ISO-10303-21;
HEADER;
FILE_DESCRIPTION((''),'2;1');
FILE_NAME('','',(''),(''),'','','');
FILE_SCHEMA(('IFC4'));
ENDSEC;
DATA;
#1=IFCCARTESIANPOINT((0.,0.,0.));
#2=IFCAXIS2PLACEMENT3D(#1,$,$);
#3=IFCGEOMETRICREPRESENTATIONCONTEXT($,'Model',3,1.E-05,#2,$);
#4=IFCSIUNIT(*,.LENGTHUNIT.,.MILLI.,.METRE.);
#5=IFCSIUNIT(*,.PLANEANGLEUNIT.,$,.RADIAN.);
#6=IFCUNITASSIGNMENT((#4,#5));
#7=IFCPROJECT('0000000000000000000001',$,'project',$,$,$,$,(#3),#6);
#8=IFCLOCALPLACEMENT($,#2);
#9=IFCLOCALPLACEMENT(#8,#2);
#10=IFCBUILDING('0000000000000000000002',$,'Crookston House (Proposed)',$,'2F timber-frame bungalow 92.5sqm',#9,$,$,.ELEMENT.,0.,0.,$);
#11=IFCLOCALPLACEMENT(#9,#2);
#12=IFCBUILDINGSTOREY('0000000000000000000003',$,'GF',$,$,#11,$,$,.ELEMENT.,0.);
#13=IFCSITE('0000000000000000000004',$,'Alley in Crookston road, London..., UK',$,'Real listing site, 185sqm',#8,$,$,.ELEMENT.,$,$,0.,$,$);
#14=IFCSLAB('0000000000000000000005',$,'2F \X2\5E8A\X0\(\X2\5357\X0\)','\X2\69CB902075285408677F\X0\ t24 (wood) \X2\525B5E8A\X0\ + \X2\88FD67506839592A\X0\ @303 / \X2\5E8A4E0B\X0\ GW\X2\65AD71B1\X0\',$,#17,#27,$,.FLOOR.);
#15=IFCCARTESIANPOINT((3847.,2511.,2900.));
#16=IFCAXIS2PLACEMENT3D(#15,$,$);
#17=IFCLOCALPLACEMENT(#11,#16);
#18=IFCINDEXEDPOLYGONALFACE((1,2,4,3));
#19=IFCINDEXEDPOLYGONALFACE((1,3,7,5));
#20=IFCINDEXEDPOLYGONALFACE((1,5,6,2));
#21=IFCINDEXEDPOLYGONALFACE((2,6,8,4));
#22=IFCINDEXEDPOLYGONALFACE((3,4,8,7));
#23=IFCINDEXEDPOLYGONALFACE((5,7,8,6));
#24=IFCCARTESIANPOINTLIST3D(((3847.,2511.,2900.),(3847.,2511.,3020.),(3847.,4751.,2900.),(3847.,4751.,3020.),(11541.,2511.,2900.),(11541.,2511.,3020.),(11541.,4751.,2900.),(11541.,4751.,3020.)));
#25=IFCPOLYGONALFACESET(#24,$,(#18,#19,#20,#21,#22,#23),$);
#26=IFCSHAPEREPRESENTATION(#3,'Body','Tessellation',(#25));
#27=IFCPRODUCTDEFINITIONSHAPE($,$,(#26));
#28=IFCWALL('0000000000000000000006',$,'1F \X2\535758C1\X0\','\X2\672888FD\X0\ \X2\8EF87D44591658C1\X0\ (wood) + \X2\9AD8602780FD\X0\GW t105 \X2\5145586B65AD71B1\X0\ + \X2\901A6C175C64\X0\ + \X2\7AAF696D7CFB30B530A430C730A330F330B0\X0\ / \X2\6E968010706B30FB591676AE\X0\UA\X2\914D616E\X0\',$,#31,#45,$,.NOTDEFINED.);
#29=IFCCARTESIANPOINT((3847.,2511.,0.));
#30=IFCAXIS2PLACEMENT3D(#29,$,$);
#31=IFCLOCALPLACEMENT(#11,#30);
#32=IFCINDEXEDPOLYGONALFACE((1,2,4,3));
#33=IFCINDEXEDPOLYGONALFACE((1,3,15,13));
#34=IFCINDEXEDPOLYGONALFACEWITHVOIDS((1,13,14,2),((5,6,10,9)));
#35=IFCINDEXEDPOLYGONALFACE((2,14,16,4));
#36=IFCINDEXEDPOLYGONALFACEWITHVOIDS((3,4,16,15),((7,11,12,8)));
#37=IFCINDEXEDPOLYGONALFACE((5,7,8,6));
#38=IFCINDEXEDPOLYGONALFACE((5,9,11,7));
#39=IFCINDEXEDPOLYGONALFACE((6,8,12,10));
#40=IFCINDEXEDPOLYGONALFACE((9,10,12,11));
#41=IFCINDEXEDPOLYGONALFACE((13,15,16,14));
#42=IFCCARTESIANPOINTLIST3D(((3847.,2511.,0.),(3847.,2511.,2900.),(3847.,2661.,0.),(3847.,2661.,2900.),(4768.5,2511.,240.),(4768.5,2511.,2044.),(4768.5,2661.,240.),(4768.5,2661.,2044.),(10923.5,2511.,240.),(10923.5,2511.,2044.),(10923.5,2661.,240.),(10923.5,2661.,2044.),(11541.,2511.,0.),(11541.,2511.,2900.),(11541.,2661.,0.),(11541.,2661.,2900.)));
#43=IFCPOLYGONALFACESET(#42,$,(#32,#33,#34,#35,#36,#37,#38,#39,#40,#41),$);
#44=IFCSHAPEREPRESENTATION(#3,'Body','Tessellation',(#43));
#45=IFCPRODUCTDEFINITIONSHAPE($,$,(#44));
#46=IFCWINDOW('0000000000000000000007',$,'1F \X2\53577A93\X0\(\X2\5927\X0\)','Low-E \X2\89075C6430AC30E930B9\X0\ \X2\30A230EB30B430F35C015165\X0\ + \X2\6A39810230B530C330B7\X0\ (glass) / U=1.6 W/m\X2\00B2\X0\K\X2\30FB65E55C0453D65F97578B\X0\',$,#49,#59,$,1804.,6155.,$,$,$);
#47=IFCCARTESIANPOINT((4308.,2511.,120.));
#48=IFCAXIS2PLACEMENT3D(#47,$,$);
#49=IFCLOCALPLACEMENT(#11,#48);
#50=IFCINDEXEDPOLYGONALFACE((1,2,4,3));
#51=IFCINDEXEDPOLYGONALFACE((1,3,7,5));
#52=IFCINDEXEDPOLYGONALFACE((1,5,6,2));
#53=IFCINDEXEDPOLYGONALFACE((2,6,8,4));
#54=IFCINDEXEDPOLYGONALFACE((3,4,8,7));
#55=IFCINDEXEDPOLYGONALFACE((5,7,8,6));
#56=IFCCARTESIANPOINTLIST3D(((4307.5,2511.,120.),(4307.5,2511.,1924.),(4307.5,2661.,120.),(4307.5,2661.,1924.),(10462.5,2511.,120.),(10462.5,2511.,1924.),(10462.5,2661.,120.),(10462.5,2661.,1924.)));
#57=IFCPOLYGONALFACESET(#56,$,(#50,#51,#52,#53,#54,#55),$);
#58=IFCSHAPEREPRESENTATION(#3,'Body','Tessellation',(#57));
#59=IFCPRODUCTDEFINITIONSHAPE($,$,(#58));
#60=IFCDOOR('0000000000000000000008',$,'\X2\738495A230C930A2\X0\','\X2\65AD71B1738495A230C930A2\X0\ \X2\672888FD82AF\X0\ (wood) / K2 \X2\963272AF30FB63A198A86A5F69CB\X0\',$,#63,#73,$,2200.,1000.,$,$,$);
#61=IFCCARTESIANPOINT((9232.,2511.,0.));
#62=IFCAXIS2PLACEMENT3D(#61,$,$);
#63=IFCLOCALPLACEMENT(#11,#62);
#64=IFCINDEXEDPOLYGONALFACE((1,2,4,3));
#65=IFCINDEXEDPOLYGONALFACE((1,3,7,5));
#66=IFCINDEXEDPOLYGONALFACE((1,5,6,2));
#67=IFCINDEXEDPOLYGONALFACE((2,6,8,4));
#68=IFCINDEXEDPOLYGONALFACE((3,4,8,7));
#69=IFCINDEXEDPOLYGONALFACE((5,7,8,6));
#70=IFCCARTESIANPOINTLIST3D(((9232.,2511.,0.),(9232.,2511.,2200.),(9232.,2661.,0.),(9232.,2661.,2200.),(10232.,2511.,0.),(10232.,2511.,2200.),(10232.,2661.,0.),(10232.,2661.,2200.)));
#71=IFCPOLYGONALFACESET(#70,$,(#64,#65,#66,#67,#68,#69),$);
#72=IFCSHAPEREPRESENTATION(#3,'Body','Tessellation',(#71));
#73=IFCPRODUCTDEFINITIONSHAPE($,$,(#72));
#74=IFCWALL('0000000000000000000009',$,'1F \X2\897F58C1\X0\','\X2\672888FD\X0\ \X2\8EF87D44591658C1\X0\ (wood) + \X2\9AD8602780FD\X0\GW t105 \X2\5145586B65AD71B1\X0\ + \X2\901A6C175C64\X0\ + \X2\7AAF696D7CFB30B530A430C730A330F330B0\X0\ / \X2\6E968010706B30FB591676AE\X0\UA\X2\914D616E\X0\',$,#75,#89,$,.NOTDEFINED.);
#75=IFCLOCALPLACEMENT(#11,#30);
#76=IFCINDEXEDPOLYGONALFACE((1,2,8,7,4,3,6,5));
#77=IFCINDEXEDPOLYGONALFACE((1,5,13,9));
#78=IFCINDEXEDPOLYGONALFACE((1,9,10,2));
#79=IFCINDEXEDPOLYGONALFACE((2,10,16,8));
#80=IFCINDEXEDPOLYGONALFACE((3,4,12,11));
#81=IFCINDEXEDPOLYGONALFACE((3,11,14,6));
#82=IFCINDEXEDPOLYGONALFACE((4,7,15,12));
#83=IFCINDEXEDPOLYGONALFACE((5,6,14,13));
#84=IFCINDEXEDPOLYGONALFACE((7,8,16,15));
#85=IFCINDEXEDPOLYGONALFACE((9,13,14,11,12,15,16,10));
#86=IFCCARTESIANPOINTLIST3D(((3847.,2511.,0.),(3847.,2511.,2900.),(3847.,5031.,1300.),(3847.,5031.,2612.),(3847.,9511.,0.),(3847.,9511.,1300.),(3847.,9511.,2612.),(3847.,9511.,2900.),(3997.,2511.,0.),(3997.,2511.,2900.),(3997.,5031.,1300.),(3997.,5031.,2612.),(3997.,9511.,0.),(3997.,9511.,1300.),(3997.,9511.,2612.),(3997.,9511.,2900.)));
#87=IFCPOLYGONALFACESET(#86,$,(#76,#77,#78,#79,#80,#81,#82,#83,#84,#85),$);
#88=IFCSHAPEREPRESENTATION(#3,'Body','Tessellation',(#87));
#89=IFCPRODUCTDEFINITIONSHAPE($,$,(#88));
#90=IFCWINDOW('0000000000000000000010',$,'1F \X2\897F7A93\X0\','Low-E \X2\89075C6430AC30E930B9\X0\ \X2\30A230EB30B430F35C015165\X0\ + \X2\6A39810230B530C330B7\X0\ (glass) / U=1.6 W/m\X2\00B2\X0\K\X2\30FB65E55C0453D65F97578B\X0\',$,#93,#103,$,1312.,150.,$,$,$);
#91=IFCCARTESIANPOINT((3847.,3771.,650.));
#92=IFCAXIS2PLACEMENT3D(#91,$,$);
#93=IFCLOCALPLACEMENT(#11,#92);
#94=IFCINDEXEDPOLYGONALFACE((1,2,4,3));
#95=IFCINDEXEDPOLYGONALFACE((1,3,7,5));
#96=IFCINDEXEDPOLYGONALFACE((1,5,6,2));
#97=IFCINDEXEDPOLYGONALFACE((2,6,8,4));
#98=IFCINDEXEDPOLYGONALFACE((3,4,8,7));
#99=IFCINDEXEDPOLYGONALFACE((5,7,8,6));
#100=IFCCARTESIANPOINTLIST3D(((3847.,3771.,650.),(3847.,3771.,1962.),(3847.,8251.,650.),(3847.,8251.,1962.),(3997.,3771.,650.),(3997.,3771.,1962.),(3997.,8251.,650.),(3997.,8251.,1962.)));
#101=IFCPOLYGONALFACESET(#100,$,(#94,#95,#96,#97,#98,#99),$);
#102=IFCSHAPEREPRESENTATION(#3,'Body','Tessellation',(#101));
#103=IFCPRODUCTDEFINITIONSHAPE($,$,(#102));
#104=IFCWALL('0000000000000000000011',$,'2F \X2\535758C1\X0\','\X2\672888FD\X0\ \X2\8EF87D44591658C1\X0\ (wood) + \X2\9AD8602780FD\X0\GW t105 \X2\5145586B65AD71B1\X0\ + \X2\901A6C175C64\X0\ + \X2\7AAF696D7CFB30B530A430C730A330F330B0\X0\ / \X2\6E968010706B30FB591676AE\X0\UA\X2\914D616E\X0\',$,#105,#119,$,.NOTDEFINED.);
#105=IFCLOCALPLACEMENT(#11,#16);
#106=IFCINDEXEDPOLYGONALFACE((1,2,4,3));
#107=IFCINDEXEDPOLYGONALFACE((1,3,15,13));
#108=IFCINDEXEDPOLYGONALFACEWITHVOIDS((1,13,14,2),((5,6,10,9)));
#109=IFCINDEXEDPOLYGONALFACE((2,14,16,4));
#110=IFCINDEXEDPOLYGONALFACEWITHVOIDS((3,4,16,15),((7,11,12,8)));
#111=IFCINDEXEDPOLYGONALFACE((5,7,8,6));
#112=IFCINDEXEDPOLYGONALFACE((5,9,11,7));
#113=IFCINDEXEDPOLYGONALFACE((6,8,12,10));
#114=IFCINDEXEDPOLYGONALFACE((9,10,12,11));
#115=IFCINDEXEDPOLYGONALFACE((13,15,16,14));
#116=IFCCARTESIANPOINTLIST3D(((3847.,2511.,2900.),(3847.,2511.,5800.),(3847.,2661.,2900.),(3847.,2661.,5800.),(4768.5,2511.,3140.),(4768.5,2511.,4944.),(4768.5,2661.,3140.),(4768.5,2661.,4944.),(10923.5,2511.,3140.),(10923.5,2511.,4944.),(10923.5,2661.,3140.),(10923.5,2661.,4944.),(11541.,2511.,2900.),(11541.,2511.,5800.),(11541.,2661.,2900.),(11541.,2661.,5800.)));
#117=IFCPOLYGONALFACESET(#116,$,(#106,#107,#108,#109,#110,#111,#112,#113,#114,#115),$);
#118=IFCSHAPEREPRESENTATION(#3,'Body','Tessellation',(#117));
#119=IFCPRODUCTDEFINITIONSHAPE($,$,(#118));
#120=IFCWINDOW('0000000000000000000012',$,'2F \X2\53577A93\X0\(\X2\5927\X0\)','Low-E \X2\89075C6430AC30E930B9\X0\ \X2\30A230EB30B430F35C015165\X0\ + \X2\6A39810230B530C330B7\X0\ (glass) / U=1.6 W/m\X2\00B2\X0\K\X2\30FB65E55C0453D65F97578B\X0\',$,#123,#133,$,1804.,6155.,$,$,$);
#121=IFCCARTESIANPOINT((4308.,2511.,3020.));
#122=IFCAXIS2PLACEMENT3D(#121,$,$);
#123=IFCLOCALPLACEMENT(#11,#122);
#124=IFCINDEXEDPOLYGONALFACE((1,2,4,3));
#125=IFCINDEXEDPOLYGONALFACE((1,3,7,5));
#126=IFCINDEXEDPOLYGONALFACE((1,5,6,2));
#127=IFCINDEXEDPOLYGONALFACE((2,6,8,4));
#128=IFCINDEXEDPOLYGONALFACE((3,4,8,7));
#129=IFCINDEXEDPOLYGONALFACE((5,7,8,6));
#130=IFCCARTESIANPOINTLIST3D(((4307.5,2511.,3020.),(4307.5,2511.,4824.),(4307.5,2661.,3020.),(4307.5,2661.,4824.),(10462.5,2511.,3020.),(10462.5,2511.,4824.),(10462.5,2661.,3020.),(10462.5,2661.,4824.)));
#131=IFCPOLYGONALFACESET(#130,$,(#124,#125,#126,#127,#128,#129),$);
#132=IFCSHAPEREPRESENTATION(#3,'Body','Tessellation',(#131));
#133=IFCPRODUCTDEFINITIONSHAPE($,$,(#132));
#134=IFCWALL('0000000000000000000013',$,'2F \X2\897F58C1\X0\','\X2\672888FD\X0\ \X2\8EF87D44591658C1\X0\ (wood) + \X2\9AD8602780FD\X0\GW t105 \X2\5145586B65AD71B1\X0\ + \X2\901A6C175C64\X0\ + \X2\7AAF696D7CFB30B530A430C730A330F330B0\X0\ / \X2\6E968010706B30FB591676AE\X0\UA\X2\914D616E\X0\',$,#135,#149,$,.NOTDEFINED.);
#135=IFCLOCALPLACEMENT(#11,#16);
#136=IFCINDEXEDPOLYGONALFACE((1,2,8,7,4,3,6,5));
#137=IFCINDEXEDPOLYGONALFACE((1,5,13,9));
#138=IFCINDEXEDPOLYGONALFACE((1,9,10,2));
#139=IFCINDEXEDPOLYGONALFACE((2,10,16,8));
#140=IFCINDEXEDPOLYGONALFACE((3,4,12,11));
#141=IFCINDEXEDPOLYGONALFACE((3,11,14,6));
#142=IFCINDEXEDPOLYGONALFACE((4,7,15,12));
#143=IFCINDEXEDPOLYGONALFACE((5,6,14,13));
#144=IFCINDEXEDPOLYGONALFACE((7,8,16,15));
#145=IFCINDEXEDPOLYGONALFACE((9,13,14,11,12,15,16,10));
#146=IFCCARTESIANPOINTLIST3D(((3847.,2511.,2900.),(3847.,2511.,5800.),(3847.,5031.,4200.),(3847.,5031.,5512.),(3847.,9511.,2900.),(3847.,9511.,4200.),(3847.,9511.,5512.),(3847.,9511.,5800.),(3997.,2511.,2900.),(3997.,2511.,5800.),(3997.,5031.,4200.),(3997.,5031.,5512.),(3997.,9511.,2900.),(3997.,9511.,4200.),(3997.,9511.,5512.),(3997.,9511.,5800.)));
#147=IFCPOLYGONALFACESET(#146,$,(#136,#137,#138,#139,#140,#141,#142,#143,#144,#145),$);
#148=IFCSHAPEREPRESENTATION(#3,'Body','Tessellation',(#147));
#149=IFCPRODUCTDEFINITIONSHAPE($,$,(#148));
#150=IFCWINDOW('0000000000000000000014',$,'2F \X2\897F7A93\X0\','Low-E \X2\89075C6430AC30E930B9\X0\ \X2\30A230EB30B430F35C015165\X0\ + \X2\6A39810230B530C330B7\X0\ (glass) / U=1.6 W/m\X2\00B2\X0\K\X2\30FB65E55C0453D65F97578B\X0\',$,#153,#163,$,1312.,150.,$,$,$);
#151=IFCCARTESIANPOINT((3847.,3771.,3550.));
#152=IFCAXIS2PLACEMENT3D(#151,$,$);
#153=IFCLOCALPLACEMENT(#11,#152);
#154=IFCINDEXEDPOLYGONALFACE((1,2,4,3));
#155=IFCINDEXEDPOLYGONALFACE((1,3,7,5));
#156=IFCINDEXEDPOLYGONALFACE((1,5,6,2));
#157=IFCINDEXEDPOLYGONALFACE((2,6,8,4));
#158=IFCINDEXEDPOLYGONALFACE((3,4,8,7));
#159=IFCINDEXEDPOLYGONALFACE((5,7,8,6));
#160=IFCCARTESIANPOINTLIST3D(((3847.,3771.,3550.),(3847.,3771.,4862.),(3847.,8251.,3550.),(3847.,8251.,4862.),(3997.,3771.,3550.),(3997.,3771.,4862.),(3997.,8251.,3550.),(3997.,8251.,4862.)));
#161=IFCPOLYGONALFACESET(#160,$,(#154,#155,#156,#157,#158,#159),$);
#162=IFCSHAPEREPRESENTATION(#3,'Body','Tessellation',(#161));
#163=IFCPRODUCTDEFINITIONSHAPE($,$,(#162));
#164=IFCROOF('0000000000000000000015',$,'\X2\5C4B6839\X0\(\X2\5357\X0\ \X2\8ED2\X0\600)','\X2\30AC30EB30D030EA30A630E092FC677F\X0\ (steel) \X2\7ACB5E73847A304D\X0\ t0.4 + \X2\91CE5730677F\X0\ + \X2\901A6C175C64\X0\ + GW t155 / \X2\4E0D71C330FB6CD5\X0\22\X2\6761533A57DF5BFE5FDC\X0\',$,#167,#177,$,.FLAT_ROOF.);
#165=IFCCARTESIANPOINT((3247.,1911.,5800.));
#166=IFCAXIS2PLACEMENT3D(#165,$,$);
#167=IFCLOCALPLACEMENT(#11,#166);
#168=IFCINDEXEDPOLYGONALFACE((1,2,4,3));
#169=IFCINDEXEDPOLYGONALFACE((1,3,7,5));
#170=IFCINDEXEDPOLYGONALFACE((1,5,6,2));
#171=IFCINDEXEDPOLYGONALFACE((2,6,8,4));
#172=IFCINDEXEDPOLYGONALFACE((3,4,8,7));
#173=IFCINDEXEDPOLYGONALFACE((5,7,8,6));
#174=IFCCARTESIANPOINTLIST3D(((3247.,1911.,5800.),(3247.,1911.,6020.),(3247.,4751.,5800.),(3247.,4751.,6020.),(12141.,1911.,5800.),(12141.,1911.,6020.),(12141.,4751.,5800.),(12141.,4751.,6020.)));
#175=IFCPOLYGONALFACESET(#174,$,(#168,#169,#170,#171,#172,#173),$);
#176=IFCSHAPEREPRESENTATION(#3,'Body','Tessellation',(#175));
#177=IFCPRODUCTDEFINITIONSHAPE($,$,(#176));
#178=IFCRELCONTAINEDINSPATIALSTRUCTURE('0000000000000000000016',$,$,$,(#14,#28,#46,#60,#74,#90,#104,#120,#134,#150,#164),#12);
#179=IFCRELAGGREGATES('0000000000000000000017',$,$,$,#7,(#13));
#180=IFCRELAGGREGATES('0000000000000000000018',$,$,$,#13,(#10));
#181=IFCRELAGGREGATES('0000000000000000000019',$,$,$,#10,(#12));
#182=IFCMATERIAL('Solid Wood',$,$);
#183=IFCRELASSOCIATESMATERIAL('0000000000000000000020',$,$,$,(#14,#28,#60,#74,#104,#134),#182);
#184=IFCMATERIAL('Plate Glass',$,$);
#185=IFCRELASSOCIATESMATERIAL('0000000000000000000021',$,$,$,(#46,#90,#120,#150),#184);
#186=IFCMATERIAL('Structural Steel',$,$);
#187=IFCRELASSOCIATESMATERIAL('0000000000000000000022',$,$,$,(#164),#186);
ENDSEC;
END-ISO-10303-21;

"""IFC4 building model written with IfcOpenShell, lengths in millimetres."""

from ifc_helpers import new_model, si_unit, frame, frame_2d, origin, place, context, project, spatial, rectangle, extrude, material, element, fill, save


model = new_model("IFC4")

# Units and contexts
model_context = context("Model", 3, precision=1e-05, world=origin())
ifc_project = project(units=[si_unit("LENGTHUNIT", "METRE", prefix="MILLI"), si_unit("PLANEANGLEUNIT", "RADIAN")], contexts=[model_context])

# Site, building, storey
site_placement = place(None, origin())
site = spatial("IfcSite", under=ifc_project, at=site_placement, Name="Alley in Crookston road, London..., UK", ObjectType="Real listing site, 185sqm", CompositionType="ELEMENT", RefElevation=0.0)
building_placement = place(site_placement, origin())
building = spatial("IfcBuilding", under=site, at=building_placement, Name="Crookston House (Proposed)", ObjectType="2F timber-frame bungalow 92.5sqm", CompositionType="ELEMENT", ElevationOfRefHeight=0.0, ElevationOfTerrain=0.0)
storey_placement = place(building_placement, origin())
storey = spatial("IfcBuildingStorey", under=building, at=storey_placement, Name="GF", CompositionType="ELEMENT", Elevation=0.0)

# Slab
ifc_material_1 = material(Name="Solid Wood")
slab_1_placement = place(storey_placement, frame((3847.0, 2511.0, 2900.0)))
element("IfcSlab", 1, at=slab_1_placement, inside=storey, material=ifc_material_1, Name="2F 床(南)", Description="構造用合板 t24 (wood) 剛床 + 製材根太 @303 / 床下 GW断熱", PredefinedType="FLOOR", context=model_context, shape_type="SweptSolid", body=[
    extrude(rectangle(XDim=7694.0, YDim=2240.0, at=frame_2d((3847.0, 1120.0))), frame((3847.0, 2511.0, 2900.0)), (0.0, 0.0, 1.0), 120.0),
])

# Wall, openings, window, door
wall_1_placement = place(storey_placement, frame((3847.0, 2511.0, 0.0)))
wall_1 = element("IfcWall", 2, at=wall_1_placement, inside=storey, material=ifc_material_1, Name="1F 南壁", Description="木製 軸組外壁 (wood) + 高性能GW t105 充填断熱 + 通気層 + 窯業系サイディング / 準耐火・外皮UA配慮", PredefinedType="NOTDEFINED", context=model_context, shape_type="SweptSolid", body=[
    extrude(rectangle(XDim=7694.0, YDim=150.0, at=frame_2d((3847.0, 75.0))), frame((3847.0, 2511.0, 0.0)), (0.0, 0.0, 1.0), 2900.0),
])
opening_1_placement = place(storey_placement, frame((4308.0, 2511.0, 120.0)))
opening_1 = element("IfcOpeningElement", 3, at=opening_1_placement, cuts=wall_1, PredefinedType="NOTDEFINED", context=model_context, shape_type="SweptSolid", body=[
    extrude(rectangle(XDim=6155.0, YDim=150.0, at=frame_2d((3077.0, 75.0))), frame((4308.0, 2511.0, 120.0)), (0.0, 0.0, 1.0), 1804.0),
])
opening_2_placement = place(storey_placement, frame((9232.0, 2511.0, 0.0)))
opening_2 = element("IfcOpeningElement", 4, at=opening_2_placement, cuts=wall_1, PredefinedType="NOTDEFINED", context=model_context, shape_type="SweptSolid", body=[
    extrude(rectangle(XDim=1000.0, YDim=150.0, at=frame_2d((500.0, 75.0))), frame((9232.0, 2511.0, 0.0)), (0.0, 0.0, 1.0), 2200.0),
])
ifc_material_2 = material(Name="Plate Glass")
window_1_placement = place(storey_placement, frame((4308.0, 2511.0, 120.0)))
window_1 = element("IfcWindow", 5, at=window_1_placement, inside=storey, material=ifc_material_2, Name="1F 南窓(大)", Description="Low-E 複層ガラス アルゴン封入 + 樹脂サッシ (glass) / U=1.6 W/m²K・日射取得型", OverallHeight=1804.0, OverallWidth=6155.0, context=model_context, shape_type="SweptSolid", body=[
    extrude(rectangle(XDim=6155.0, YDim=150.0, at=frame_2d((3077.0, 75.0))), frame((4308.0, 2511.0, 120.0)), (0.0, 0.0, 1.0), 1804.0),
])
fill(opening_1, window_1)
door_placement = place(storey_placement, frame((9232.0, 2511.0, 0.0)))
door = element("IfcDoor", 6, at=door_placement, inside=storey, material=ifc_material_1, Name="玄関ドア", Description="断熱玄関ドア 木製芯 (wood) / K2 防犯・採風機構", OverallHeight=2200.0, OverallWidth=1000.0, context=model_context, shape_type="SweptSolid", body=[
    extrude(rectangle(XDim=1000.0, YDim=150.0, at=frame_2d((500.0, 75.0))), frame((9232.0, 2511.0, 0.0)), (0.0, 0.0, 1.0), 2200.0),
])
fill(opening_2, door)

# Walls, openings, windows
wall_2_placement = place(storey_placement, frame((3847.0, 2511.0, 0.0)))
wall_2 = element("IfcWall", 7, at=wall_2_placement, inside=storey, material=ifc_material_1, Name="1F 西壁", Description="木製 軸組外壁 (wood) + 高性能GW t105 充填断熱 + 通気層 + 窯業系サイディング / 準耐火・外皮UA配慮", PredefinedType="NOTDEFINED", context=model_context, shape_type="SweptSolid", body=[
    extrude(rectangle(XDim=150.0, YDim=7000.0, at=frame_2d((75.0, 3500.0))), frame((3847.0, 2511.0, 0.0)), (0.0, 0.0, 1.0), 2900.0),
])
opening_3_placement = place(storey_placement, frame((3847.0, 3771.0, 650.0)))
opening_3 = element("IfcOpeningElement", 8, at=opening_3_placement, cuts=wall_2, PredefinedType="NOTDEFINED", context=model_context, shape_type="SweptSolid", body=[
    extrude(rectangle(XDim=150.0, YDim=4480.0, at=frame_2d((75.0, 2240.0))), frame((3847.0, 3771.0, 650.0)), (0.0, 0.0, 1.0), 1312.0),
])
window_2_placement = place(storey_placement, frame((3847.0, 3771.0, 650.0)))
window_2 = element("IfcWindow", 9, at=window_2_placement, inside=storey, material=ifc_material_2, Name="1F 西窓", Description="Low-E 複層ガラス アルゴン封入 + 樹脂サッシ (glass) / U=1.6 W/m²K・日射取得型", OverallHeight=1312.0, OverallWidth=150.0, context=model_context, shape_type="SweptSolid", body=[
    extrude(rectangle(XDim=150.0, YDim=4480.0, at=frame_2d((75.0, 2240.0))), frame((3847.0, 3771.0, 650.0)), (0.0, 0.0, 1.0), 1312.0),
])
fill(opening_3, window_2)
wall_3_placement = place(storey_placement, frame((3847.0, 2511.0, 2900.0)))
wall_3 = element("IfcWall", 10, at=wall_3_placement, inside=storey, material=ifc_material_1, Name="2F 南壁", Description="木製 軸組外壁 (wood) + 高性能GW t105 充填断熱 + 通気層 + 窯業系サイディング / 準耐火・外皮UA配慮", PredefinedType="NOTDEFINED", context=model_context, shape_type="SweptSolid", body=[
    extrude(rectangle(XDim=7694.0, YDim=150.0, at=frame_2d((3847.0, 75.0))), frame((3847.0, 2511.0, 2900.0)), (0.0, 0.0, 1.0), 2900.0),
])
opening_4_placement = place(storey_placement, frame((4308.0, 2511.0, 3020.0)))
opening_4 = element("IfcOpeningElement", 11, at=opening_4_placement, cuts=wall_3, PredefinedType="NOTDEFINED", context=model_context, shape_type="SweptSolid", body=[
    extrude(rectangle(XDim=6155.0, YDim=150.0, at=frame_2d((3077.0, 75.0))), frame((4308.0, 2511.0, 3020.0)), (0.0, 0.0, 1.0), 1804.0),
])
window_3_placement = place(storey_placement, frame((4308.0, 2511.0, 3020.0)))
window_3 = element("IfcWindow", 12, at=window_3_placement, inside=storey, material=ifc_material_2, Name="2F 南窓(大)", Description="Low-E 複層ガラス アルゴン封入 + 樹脂サッシ (glass) / U=1.6 W/m²K・日射取得型", OverallHeight=1804.0, OverallWidth=6155.0, context=model_context, shape_type="SweptSolid", body=[
    extrude(rectangle(XDim=6155.0, YDim=150.0, at=frame_2d((3077.0, 75.0))), frame((4308.0, 2511.0, 3020.0)), (0.0, 0.0, 1.0), 1804.0),
])
fill(opening_4, window_3)
wall_4_placement = place(storey_placement, frame((3847.0, 2511.0, 2900.0)))
wall_4 = element("IfcWall", 13, at=wall_4_placement, inside=storey, material=ifc_material_1, Name="2F 西壁", Description="木製 軸組外壁 (wood) + 高性能GW t105 充填断熱 + 通気層 + 窯業系サイディング / 準耐火・外皮UA配慮", PredefinedType="NOTDEFINED", context=model_context, shape_type="SweptSolid", body=[
    extrude(rectangle(XDim=150.0, YDim=7000.0, at=frame_2d((75.0, 3500.0))), frame((3847.0, 2511.0, 2900.0)), (0.0, 0.0, 1.0), 2900.0),
])
opening_5_placement = place(storey_placement, frame((3847.0, 3771.0, 3550.0)))
opening_5 = element("IfcOpeningElement", 14, at=opening_5_placement, cuts=wall_4, PredefinedType="NOTDEFINED", context=model_context, shape_type="SweptSolid", body=[
    extrude(rectangle(XDim=150.0, YDim=4480.0, at=frame_2d((75.0, 2240.0))), frame((3847.0, 3771.0, 3550.0)), (0.0, 0.0, 1.0), 1312.0),
])
window_4_placement = place(storey_placement, frame((3847.0, 3771.0, 3550.0)))
window_4 = element("IfcWindow", 15, at=window_4_placement, inside=storey, material=ifc_material_2, Name="2F 西窓", Description="Low-E 複層ガラス アルゴン封入 + 樹脂サッシ (glass) / U=1.6 W/m²K・日射取得型", OverallHeight=1312.0, OverallWidth=150.0, context=model_context, shape_type="SweptSolid", body=[
    extrude(rectangle(XDim=150.0, YDim=4480.0, at=frame_2d((75.0, 2240.0))), frame((3847.0, 3771.0, 3550.0)), (0.0, 0.0, 1.0), 1312.0),
])
fill(opening_5, window_4)

# Roof
ifc_material_3 = material(Name="Structural Steel")
roof_1_placement = place(storey_placement, frame((3247.0, 1911.0, 5800.0)))
element("IfcRoof", 16, at=roof_1_placement, inside=storey, material=ifc_material_3, Name="屋根(南 軒600)", Description="ガルバリウム鋼板 (steel) 立平葺き t0.4 + 野地板 + 通気層 + GW t155 / 不燃・法22条区域対応", PredefinedType="FLAT_ROOF", context=model_context, shape_type="SweptSolid", body=[
    extrude(rectangle(XDim=8894.0, YDim=2840.0, at=frame_2d((4447.0, 1420.0))), frame((3247.0, 1911.0, 5800.0)), (0.0, 0.0, 1.0), 220.0),
])

save(model, "model.ifc")
